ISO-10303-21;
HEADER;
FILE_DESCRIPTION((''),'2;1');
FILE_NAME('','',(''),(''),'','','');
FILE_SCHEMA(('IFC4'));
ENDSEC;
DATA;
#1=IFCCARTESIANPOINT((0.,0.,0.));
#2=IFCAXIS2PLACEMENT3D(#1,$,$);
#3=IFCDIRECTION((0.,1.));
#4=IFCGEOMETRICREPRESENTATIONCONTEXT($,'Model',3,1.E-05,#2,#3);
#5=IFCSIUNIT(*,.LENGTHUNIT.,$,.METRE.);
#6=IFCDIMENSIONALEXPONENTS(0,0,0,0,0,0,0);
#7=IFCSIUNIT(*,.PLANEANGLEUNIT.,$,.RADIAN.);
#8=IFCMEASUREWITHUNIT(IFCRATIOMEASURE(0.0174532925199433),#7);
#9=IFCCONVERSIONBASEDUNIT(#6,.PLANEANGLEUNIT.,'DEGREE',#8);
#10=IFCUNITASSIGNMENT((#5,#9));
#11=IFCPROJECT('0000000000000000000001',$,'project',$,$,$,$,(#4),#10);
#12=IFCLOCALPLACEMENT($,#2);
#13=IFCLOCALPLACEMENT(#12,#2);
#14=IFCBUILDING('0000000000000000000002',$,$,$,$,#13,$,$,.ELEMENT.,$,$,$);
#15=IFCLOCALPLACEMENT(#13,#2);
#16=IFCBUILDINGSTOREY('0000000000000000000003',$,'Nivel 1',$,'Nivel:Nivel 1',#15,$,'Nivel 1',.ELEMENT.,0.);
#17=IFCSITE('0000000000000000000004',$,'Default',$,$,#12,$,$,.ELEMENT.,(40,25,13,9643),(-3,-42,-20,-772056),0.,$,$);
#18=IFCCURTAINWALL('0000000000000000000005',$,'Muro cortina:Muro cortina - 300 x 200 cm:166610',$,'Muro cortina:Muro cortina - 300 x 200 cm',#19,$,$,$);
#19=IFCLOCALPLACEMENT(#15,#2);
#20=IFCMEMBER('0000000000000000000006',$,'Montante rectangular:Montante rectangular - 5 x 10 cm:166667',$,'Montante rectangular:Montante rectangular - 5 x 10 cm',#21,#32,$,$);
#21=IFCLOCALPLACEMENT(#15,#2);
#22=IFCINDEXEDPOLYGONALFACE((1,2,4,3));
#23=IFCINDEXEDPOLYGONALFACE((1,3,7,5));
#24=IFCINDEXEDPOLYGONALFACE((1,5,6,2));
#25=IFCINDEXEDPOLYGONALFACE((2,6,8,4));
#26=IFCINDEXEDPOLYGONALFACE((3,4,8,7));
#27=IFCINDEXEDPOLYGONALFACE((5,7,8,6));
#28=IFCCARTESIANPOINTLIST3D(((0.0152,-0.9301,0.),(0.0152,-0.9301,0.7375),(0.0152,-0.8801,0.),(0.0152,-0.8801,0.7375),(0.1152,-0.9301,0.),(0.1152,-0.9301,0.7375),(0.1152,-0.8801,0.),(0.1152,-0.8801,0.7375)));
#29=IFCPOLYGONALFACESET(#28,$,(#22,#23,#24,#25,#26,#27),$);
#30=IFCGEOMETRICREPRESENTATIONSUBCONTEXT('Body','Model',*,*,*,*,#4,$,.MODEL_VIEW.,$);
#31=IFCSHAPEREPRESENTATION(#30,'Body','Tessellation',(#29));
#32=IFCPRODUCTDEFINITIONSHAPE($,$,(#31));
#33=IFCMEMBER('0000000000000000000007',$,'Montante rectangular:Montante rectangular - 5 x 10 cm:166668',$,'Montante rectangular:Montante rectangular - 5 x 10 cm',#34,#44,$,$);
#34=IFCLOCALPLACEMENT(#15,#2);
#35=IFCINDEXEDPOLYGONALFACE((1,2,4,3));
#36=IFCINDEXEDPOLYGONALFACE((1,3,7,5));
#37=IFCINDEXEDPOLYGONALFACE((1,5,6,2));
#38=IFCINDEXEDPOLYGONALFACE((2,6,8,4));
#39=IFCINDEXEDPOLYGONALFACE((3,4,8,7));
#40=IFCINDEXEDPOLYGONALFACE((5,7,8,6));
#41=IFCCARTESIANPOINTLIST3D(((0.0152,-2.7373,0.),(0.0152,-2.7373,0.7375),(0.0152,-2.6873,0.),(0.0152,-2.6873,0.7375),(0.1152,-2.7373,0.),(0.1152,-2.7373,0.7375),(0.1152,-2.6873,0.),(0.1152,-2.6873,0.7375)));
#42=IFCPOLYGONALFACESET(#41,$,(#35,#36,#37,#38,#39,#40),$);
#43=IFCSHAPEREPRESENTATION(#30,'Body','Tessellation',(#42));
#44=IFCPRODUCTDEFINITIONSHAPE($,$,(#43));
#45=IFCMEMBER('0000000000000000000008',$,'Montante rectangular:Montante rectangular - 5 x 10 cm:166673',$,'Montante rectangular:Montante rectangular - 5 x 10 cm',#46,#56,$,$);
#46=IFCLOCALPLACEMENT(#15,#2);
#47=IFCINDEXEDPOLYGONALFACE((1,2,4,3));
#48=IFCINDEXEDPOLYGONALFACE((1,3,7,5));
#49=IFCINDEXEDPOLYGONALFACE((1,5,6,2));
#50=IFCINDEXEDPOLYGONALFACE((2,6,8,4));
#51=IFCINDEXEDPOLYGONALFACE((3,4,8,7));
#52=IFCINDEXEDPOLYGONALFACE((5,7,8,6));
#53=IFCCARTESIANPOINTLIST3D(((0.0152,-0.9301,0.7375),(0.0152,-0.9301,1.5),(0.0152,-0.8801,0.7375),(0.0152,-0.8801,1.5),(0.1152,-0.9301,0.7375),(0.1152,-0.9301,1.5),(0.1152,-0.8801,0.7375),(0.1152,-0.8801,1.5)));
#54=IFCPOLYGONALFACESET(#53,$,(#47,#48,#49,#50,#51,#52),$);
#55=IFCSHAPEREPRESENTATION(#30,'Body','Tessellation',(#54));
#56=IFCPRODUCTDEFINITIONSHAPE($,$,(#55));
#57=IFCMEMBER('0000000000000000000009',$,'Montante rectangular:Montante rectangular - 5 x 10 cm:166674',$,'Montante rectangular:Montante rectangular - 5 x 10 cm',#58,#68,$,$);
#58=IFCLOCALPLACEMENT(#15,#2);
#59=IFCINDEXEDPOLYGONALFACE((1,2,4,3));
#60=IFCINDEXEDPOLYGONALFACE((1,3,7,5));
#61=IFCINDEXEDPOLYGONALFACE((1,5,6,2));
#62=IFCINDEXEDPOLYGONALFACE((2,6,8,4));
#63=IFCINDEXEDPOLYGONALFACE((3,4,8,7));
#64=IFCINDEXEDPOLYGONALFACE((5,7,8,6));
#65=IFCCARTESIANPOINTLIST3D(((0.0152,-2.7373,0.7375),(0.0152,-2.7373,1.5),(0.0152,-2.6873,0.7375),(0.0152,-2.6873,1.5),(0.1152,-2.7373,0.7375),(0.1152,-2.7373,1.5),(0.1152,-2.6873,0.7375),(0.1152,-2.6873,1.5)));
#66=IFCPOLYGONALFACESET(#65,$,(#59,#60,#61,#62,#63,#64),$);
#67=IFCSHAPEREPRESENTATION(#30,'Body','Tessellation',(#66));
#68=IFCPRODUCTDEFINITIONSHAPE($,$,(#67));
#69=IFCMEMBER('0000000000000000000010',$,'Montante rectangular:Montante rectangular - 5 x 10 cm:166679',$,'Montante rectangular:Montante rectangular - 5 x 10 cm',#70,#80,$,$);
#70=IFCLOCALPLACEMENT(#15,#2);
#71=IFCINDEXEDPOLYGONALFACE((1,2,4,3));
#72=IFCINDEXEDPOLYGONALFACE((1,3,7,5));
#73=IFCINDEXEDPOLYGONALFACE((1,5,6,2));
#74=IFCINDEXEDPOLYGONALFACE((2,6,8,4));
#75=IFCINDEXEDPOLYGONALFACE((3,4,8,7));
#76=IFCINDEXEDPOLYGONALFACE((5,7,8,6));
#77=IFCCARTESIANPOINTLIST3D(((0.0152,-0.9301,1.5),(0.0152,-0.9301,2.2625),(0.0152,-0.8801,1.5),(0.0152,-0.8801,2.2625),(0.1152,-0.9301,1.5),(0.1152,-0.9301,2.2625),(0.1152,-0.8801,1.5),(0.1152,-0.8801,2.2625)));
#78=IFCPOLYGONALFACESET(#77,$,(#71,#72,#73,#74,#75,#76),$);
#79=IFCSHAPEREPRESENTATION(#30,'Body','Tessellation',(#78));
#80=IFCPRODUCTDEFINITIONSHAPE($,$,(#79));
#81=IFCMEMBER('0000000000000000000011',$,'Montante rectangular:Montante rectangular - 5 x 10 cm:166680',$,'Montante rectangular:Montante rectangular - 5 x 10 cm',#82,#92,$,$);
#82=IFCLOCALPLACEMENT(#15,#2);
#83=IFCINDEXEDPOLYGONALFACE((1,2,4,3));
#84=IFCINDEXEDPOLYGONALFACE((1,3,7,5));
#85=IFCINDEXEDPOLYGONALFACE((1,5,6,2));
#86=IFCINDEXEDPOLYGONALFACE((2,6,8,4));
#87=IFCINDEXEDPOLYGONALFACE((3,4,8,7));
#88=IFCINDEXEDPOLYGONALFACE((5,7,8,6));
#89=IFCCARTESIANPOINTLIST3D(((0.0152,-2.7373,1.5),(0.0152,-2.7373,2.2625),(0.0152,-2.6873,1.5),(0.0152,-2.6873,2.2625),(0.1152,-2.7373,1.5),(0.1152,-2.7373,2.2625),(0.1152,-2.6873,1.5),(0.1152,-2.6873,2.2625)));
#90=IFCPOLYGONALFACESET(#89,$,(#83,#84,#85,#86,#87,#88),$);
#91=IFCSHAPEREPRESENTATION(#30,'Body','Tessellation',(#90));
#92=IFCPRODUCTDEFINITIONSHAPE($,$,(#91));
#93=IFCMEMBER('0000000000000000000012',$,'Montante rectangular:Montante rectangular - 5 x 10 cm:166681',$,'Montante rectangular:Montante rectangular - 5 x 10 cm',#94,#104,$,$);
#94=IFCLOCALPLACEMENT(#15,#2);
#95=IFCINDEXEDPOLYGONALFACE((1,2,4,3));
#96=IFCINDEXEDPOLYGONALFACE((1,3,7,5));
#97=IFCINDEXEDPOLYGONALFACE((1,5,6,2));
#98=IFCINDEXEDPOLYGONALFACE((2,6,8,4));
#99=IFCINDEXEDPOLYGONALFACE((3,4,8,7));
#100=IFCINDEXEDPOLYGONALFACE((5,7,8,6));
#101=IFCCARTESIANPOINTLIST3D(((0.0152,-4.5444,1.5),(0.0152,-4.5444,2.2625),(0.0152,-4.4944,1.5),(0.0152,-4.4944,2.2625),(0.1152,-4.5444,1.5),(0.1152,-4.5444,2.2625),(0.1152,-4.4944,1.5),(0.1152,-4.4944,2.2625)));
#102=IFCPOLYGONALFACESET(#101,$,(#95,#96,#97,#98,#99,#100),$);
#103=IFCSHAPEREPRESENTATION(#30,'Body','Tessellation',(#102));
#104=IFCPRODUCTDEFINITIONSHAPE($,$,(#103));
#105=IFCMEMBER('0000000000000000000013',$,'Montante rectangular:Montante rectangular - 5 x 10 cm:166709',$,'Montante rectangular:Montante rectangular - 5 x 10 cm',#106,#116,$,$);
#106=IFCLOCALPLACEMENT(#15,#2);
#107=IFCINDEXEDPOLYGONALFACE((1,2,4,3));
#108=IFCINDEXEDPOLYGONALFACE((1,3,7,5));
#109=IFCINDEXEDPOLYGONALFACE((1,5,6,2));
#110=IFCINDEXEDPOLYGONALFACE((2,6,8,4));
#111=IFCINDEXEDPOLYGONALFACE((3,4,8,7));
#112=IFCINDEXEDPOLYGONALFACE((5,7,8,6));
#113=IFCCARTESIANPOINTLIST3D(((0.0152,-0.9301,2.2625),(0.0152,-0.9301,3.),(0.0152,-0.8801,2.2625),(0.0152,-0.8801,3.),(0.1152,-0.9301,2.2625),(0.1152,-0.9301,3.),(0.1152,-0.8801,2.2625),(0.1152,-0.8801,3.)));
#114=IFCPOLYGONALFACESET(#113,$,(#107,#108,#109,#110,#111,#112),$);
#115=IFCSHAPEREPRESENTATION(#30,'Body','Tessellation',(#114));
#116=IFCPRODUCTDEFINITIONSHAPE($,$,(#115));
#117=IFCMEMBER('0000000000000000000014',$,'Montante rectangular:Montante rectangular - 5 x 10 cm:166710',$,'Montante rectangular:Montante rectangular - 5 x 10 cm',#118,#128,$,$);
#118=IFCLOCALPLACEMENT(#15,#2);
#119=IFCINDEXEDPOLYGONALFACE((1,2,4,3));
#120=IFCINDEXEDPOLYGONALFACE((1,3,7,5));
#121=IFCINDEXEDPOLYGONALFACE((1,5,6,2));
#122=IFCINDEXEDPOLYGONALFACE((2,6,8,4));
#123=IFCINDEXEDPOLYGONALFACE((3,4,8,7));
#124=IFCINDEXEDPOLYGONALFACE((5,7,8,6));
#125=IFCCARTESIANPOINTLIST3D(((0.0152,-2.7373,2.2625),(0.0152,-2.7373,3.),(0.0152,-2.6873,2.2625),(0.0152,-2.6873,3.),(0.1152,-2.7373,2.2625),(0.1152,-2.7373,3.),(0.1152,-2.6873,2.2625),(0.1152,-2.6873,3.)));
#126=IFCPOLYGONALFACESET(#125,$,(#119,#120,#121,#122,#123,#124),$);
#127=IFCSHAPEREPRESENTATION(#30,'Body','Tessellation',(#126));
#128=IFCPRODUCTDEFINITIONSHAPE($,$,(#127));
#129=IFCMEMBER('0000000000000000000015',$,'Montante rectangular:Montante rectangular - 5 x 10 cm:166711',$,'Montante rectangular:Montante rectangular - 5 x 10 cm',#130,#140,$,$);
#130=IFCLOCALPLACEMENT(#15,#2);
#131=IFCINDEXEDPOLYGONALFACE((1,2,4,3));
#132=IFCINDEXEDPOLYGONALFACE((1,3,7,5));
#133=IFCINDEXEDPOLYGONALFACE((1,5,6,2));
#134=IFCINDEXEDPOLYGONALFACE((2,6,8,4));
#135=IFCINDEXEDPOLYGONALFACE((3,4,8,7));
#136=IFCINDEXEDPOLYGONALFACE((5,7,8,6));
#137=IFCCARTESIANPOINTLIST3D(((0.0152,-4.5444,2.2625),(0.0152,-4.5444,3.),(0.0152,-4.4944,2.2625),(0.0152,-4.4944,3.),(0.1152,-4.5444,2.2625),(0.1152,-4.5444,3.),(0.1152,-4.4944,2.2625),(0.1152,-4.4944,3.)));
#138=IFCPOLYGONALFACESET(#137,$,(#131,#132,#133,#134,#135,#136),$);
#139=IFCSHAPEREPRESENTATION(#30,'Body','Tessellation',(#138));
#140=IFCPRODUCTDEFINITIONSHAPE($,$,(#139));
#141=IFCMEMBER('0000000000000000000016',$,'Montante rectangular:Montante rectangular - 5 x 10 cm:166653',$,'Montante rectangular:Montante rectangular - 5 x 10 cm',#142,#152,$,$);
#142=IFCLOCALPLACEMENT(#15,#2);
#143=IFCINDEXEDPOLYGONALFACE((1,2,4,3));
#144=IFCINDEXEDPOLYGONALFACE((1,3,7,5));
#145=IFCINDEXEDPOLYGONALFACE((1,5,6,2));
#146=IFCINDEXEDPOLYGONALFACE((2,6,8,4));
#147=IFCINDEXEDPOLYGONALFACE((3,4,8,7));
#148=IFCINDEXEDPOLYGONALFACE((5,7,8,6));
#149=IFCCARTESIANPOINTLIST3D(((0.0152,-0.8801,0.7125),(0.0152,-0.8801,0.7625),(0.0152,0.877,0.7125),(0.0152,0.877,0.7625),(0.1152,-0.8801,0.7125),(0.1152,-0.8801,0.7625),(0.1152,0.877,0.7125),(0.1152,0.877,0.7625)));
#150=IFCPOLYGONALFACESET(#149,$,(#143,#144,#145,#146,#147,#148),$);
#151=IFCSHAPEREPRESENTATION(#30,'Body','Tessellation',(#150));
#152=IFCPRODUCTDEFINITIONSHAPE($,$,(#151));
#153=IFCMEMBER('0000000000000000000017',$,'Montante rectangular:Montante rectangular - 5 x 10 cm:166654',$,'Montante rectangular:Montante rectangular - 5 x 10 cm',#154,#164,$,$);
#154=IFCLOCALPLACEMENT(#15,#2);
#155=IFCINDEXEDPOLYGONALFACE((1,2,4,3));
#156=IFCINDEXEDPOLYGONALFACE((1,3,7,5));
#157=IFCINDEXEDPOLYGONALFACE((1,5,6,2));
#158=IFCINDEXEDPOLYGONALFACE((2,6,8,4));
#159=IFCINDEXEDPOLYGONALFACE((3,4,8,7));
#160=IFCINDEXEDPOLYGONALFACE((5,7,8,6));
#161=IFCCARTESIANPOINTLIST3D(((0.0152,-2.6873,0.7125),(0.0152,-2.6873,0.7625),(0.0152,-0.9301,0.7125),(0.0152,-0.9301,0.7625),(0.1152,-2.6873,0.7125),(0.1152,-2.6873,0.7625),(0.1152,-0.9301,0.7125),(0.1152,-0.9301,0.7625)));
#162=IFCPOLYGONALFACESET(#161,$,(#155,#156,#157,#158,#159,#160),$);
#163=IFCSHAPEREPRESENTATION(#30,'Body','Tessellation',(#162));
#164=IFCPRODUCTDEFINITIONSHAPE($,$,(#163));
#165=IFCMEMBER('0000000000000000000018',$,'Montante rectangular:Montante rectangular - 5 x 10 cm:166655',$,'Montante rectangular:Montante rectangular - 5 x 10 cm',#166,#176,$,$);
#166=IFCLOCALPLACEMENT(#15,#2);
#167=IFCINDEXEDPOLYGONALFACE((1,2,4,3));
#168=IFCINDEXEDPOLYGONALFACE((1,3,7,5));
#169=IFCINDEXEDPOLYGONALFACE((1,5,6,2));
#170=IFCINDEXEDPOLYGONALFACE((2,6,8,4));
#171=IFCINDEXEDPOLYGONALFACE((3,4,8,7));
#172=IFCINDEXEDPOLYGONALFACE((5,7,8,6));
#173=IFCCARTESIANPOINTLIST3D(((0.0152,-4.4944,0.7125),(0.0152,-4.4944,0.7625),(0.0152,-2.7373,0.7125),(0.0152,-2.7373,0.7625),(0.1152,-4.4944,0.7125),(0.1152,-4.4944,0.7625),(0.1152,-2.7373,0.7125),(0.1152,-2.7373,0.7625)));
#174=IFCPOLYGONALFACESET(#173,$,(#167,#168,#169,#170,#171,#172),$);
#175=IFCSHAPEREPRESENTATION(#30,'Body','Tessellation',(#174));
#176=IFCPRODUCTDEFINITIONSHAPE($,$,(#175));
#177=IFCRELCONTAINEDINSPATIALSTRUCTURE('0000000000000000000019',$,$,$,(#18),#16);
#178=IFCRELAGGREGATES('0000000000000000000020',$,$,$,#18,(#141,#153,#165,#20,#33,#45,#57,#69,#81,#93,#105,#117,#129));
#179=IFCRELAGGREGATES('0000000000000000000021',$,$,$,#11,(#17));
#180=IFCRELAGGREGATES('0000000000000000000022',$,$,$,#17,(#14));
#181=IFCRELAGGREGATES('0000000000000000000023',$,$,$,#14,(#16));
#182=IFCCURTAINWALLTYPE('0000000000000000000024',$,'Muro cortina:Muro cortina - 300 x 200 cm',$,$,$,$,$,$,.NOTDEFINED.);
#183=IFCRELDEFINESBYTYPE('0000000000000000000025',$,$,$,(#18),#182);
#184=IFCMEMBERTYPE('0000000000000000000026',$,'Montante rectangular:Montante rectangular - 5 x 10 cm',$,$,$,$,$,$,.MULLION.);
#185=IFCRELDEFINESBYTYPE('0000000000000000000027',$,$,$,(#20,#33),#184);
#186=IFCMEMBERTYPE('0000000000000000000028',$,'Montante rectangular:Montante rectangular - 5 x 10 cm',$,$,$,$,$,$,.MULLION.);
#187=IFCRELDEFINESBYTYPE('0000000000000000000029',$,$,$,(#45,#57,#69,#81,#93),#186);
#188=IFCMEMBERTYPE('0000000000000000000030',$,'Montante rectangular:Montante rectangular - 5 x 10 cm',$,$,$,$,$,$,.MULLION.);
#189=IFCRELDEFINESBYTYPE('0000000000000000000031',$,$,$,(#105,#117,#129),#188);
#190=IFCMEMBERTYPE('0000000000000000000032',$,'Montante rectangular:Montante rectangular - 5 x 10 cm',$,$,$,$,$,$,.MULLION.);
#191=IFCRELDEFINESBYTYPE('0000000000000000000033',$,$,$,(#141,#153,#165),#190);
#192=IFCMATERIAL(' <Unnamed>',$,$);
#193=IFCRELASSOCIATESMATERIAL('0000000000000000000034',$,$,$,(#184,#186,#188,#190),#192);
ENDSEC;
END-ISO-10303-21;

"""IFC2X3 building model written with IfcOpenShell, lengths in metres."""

from ifc_helpers import new_model, entity, si_unit, converted_unit, direction, frame, origin, origin_2d_with_axis, place, context, subcontext, project, spatial, rectangle, extrude, source, transform, mapped, material, type_object, type_shapes, element, aggregate, save


model = new_model("IFC2X3")

# Units and contexts
model_context = context("Model", 3, precision=1e-05, world=origin(), true_north=direction((0.0, 1.0)))
body_context = subcontext(model_context, "Body", "Model", "MODEL_VIEW")
ifc_project = project(units=[si_unit("LENGTHUNIT", "METRE"), converted_unit("PLANEANGLEUNIT", "DEGREE", entity("IfcRatioMeasure", 0.0174532925199433), si_unit("PLANEANGLEUNIT", "RADIAN"), dimensions=[0, 0, 0, 0, 0, 0, 0])], contexts=[model_context])

# Site, building, storey
site_placement = place(None, origin())
site = spatial("IfcSite", under=ifc_project, at=site_placement, Name="Default", CompositionType="ELEMENT", RefLatitude=(40, 25, 13, 9643), RefLongitude=(-3, -42, -20, -772056), RefElevation=0.0)
building_placement = place(site_placement, origin())
building = spatial("IfcBuilding", under=site, at=building_placement, CompositionType="ELEMENT")
storey_placement = place(building_placement, origin())
storey = spatial("IfcBuildingStorey", under=building, at=storey_placement, Name="Nivel 1", ObjectType="Nivel:Nivel 1", LongName="Nivel 1", CompositionType="ELEMENT", Elevation=0.0)

# Curtain wall, members
curtain_wall_type = type_object("IfcCurtainWallType", Name="Muro cortina:Muro cortina - 300 x 200 cm", PredefinedType="NOTDEFINED")
curtain_wall_placement = place(storey_placement, origin())
curtain_wall = element("IfcCurtainWall", 1, at=curtain_wall_placement, inside=storey, type_object=curtain_wall_type, Name="Muro cortina:Muro cortina - 300 x 200 cm:166610", ObjectType="Muro cortina:Muro cortina - 300 x 200 cm")
ifc_material_1 = material(Name=" <Unnamed>")
member_type_1 = type_object("IfcMemberType", Name="Montante rectangular:Montante rectangular - 5 x 10 cm", PredefinedType="MULLION", material=ifc_material_1)
shared_shape_1 = source(origin(), body_context, "Body", "SweptSolid", [
    extrude(rectangle(XDim=0.1, YDim=0.05, at=origin_2d_with_axis()), frame((0.0, 0.0, -0.7375), z_axis=(0.0, 0.0, 1.0), x_axis=(0.0, -1.0, 0.0)), (0.0, 0.0, 1.0), 0.7375),
])
type_shapes(member_type_1, [shared_shape_1])
member_1_placement = place(storey_placement, frame((0.0652, -0.9051, 0.0), z_axis=(0.0, 0.0, -1.0), x_axis=(0.0, -1.0, 0.0)))
member_1 = element("IfcMember", 2, at=member_1_placement, type_object=member_type_1, Name="Montante rectangular:Montante rectangular - 5 x 10 cm:166667", ObjectType="Montante rectangular:Montante rectangular - 5 x 10 cm", context=body_context, shape_type="MappedRepresentation", body=[
    mapped(shared_shape_1, transform((0.0, 0.0, 0.0), scale=1.0)),
])
member_2_placement = place(storey_placement, frame((0.0652, -2.7123, 0.0), z_axis=(0.0, 0.0, -1.0), x_axis=(0.0, -1.0, 0.0)))
member_2 = element("IfcMember", 3, at=member_2_placement, type_object=member_type_1, Name="Montante rectangular:Montante rectangular - 5 x 10 cm:166668", ObjectType="Montante rectangular:Montante rectangular - 5 x 10 cm", context=body_context, shape_type="MappedRepresentation", body=[
    mapped(shared_shape_1, transform((0.0, 0.0, 0.0), scale=1.0)),
])
member_type_2 = type_object("IfcMemberType", Name="Montante rectangular:Montante rectangular - 5 x 10 cm", PredefinedType="MULLION", material=ifc_material_1)
shared_shape_2 = source(origin(), body_context, "Body", "SweptSolid", [
    extrude(rectangle(XDim=0.1, YDim=0.05, at=origin_2d_with_axis()), frame((0.0, 0.0, -0.7625), z_axis=(0.0, 0.0, 1.0), x_axis=(0.0, -1.0, 0.0)), (0.0, 0.0, 1.0), 0.7625),
])
type_shapes(member_type_2, [shared_shape_2])
member_3_placement = place(storey_placement, frame((0.0652, -0.9051, 0.7375), z_axis=(0.0, 0.0, -1.0), x_axis=(0.0, -1.0, 0.0)))
member_3 = element("IfcMember", 4, at=member_3_placement, type_object=member_type_2, Name="Montante rectangular:Montante rectangular - 5 x 10 cm:166673", ObjectType="Montante rectangular:Montante rectangular - 5 x 10 cm", context=body_context, shape_type="MappedRepresentation", body=[
    mapped(shared_shape_2, transform((0.0, 0.0, 0.0), scale=1.0)),
])
member_4_placement = place(storey_placement, frame((0.0652, -2.7123, 0.7375), z_axis=(0.0, 0.0, -1.0), x_axis=(0.0, -1.0, 0.0)))
member_4 = element("IfcMember", 5, at=member_4_placement, type_object=member_type_2, Name="Montante rectangular:Montante rectangular - 5 x 10 cm:166674", ObjectType="Montante rectangular:Montante rectangular - 5 x 10 cm", context=body_context, shape_type="MappedRepresentation", body=[
    mapped(shared_shape_2, transform((0.0, 0.0, 0.0), scale=1.0)),
])
member_5_placement = place(storey_placement, frame((0.0652, -0.9051, 1.5), z_axis=(0.0, 0.0, -1.0), x_axis=(0.0, -1.0, 0.0)))
member_5 = element("IfcMember", 6, at=member_5_placement, type_object=member_type_2, Name="Montante rectangular:Montante rectangular - 5 x 10 cm:166679", ObjectType="Montante rectangular:Montante rectangular - 5 x 10 cm", context=body_context, shape_type="MappedRepresentation", body=[
    mapped(shared_shape_2, transform((0.0, 0.0, 0.0), scale=1.0)),
])
member_6_placement = place(storey_placement, frame((0.0652, -2.7123, 1.5), z_axis=(0.0, 0.0, -1.0), x_axis=(0.0, -1.0, 0.0)))
member_6 = element("IfcMember", 7, at=member_6_placement, type_object=member_type_2, Name="Montante rectangular:Montante rectangular - 5 x 10 cm:166680", ObjectType="Montante rectangular:Montante rectangular - 5 x 10 cm", context=body_context, shape_type="MappedRepresentation", body=[
    mapped(shared_shape_2, transform((0.0, 0.0, 0.0), scale=1.0)),
])
member_7_placement = place(storey_placement, frame((0.0652, -4.5194, 1.5), z_axis=(0.0, 0.0, -1.0), x_axis=(0.0, -1.0, 0.0)))
member_7 = element("IfcMember", 8, at=member_7_placement, type_object=member_type_2, Name="Montante rectangular:Montante rectangular - 5 x 10 cm:166681", ObjectType="Montante rectangular:Montante rectangular - 5 x 10 cm", context=body_context, shape_type="MappedRepresentation", body=[
    mapped(shared_shape_2, transform((0.0, 0.0, 0.0), scale=1.0)),
])
member_type_3 = type_object("IfcMemberType", Name="Montante rectangular:Montante rectangular - 5 x 10 cm", PredefinedType="MULLION", material=ifc_material_1)
shared_shape_3 = source(origin(), body_context, "Body", "SweptSolid", [
    extrude(rectangle(XDim=0.1, YDim=0.05, at=origin_2d_with_axis()), frame((0.0, 0.0, -0.7375), z_axis=(0.0, 0.0, 1.0), x_axis=(0.0, -1.0, 0.0)), (0.0, 0.0, 1.0), 0.7375),
])
type_shapes(member_type_3, [shared_shape_3])
member_8_placement = place(storey_placement, frame((0.0652, -0.9051, 2.2625), z_axis=(0.0, 0.0, -1.0), x_axis=(0.0, -1.0, 0.0)))
member_8 = element("IfcMember", 9, at=member_8_placement, type_object=member_type_3, Name="Montante rectangular:Montante rectangular - 5 x 10 cm:166709", ObjectType="Montante rectangular:Montante rectangular - 5 x 10 cm", context=body_context, shape_type="MappedRepresentation", body=[
    mapped(shared_shape_3, transform((0.0, 0.0, 0.0), scale=1.0)),
])
member_9_placement = place(storey_placement, frame((0.0652, -2.7123, 2.2625), z_axis=(0.0, 0.0, -1.0), x_axis=(0.0, -1.0, 0.0)))
member_9 = element("IfcMember", 10, at=member_9_placement, type_object=member_type_3, Name="Montante rectangular:Montante rectangular - 5 x 10 cm:166710", ObjectType="Montante rectangular:Montante rectangular - 5 x 10 cm", context=body_context, shape_type="MappedRepresentation", body=[
    mapped(shared_shape_3, transform((0.0, 0.0, 0.0), scale=1.0)),
])
member_10_placement = place(storey_placement, frame((0.0652, -4.5194, 2.2625), z_axis=(0.0, 0.0, -1.0), x_axis=(0.0, -1.0, 0.0)))
member_10 = element("IfcMember", 11, at=member_10_placement, type_object=member_type_3, Name="Montante rectangular:Montante rectangular - 5 x 10 cm:166711", ObjectType="Montante rectangular:Montante rectangular - 5 x 10 cm", context=body_context, shape_type="MappedRepresentation", body=[
    mapped(shared_shape_3, transform((0.0, 0.0, 0.0), scale=1.0)),
])
member_type_4 = type_object("IfcMemberType", Name="Montante rectangular:Montante rectangular - 5 x 10 cm", PredefinedType="MULLION", material=ifc_material_1)
shared_shape_4 = source(origin(), body_context, "Body", "SweptSolid", [
    extrude(rectangle(XDim=0.1, YDim=0.05, at=origin_2d_with_axis()), frame((0.0, 0.0, -1.7571), z_axis=(0.0, 0.0, 1.0), x_axis=(0.0, -1.0, 0.0)), (0.0, 0.0, 1.0), 1.7571),
])
type_shapes(member_type_4, [shared_shape_4])
member_11_placement = place(storey_placement, frame((0.0652, -0.8801, 0.7375), z_axis=(0.0, -1.0, 0.0), x_axis=(0.0, 0.0, 1.0)))
member_11 = element("IfcMember", 12, at=member_11_placement, type_object=member_type_4, Name="Montante rectangular:Montante rectangular - 5 x 10 cm:166653", ObjectType="Montante rectangular:Montante rectangular - 5 x 10 cm", context=body_context, shape_type="MappedRepresentation", body=[
    mapped(shared_shape_4, transform((0.0, 0.0, 0.0), scale=1.0)),
])
member_12_placement = place(storey_placement, frame((0.0652, -2.6873, 0.7375), z_axis=(0.0, -1.0, 0.0), x_axis=(0.0, 0.0, 1.0)))
member_12 = element("IfcMember", 13, at=member_12_placement, type_object=member_type_4, Name="Montante rectangular:Montante rectangular - 5 x 10 cm:166654", ObjectType="Montante rectangular:Montante rectangular - 5 x 10 cm", context=body_context, shape_type="MappedRepresentation", body=[
    mapped(shared_shape_4, transform((0.0, 0.0, 0.0), scale=1.0)),
])
member_13_placement = place(storey_placement, frame((0.0652, -4.4944, 0.7375), z_axis=(0.0, -1.0, 0.0), x_axis=(0.0, 0.0, 1.0)))
member_13 = element("IfcMember", 14, at=member_13_placement, type_object=member_type_4, Name="Montante rectangular:Montante rectangular - 5 x 10 cm:166655", ObjectType="Montante rectangular:Montante rectangular - 5 x 10 cm", context=body_context, shape_type="MappedRepresentation", body=[
    mapped(shared_shape_4, transform((0.0, 0.0, 0.0), scale=1.0)),
])
aggregate(curtain_wall, [member_11, member_12, member_13, member_1, member_2, member_3, member_4, member_5, member_6, member_7, member_8, member_9, member_10])

save(model, "model.ifc")
